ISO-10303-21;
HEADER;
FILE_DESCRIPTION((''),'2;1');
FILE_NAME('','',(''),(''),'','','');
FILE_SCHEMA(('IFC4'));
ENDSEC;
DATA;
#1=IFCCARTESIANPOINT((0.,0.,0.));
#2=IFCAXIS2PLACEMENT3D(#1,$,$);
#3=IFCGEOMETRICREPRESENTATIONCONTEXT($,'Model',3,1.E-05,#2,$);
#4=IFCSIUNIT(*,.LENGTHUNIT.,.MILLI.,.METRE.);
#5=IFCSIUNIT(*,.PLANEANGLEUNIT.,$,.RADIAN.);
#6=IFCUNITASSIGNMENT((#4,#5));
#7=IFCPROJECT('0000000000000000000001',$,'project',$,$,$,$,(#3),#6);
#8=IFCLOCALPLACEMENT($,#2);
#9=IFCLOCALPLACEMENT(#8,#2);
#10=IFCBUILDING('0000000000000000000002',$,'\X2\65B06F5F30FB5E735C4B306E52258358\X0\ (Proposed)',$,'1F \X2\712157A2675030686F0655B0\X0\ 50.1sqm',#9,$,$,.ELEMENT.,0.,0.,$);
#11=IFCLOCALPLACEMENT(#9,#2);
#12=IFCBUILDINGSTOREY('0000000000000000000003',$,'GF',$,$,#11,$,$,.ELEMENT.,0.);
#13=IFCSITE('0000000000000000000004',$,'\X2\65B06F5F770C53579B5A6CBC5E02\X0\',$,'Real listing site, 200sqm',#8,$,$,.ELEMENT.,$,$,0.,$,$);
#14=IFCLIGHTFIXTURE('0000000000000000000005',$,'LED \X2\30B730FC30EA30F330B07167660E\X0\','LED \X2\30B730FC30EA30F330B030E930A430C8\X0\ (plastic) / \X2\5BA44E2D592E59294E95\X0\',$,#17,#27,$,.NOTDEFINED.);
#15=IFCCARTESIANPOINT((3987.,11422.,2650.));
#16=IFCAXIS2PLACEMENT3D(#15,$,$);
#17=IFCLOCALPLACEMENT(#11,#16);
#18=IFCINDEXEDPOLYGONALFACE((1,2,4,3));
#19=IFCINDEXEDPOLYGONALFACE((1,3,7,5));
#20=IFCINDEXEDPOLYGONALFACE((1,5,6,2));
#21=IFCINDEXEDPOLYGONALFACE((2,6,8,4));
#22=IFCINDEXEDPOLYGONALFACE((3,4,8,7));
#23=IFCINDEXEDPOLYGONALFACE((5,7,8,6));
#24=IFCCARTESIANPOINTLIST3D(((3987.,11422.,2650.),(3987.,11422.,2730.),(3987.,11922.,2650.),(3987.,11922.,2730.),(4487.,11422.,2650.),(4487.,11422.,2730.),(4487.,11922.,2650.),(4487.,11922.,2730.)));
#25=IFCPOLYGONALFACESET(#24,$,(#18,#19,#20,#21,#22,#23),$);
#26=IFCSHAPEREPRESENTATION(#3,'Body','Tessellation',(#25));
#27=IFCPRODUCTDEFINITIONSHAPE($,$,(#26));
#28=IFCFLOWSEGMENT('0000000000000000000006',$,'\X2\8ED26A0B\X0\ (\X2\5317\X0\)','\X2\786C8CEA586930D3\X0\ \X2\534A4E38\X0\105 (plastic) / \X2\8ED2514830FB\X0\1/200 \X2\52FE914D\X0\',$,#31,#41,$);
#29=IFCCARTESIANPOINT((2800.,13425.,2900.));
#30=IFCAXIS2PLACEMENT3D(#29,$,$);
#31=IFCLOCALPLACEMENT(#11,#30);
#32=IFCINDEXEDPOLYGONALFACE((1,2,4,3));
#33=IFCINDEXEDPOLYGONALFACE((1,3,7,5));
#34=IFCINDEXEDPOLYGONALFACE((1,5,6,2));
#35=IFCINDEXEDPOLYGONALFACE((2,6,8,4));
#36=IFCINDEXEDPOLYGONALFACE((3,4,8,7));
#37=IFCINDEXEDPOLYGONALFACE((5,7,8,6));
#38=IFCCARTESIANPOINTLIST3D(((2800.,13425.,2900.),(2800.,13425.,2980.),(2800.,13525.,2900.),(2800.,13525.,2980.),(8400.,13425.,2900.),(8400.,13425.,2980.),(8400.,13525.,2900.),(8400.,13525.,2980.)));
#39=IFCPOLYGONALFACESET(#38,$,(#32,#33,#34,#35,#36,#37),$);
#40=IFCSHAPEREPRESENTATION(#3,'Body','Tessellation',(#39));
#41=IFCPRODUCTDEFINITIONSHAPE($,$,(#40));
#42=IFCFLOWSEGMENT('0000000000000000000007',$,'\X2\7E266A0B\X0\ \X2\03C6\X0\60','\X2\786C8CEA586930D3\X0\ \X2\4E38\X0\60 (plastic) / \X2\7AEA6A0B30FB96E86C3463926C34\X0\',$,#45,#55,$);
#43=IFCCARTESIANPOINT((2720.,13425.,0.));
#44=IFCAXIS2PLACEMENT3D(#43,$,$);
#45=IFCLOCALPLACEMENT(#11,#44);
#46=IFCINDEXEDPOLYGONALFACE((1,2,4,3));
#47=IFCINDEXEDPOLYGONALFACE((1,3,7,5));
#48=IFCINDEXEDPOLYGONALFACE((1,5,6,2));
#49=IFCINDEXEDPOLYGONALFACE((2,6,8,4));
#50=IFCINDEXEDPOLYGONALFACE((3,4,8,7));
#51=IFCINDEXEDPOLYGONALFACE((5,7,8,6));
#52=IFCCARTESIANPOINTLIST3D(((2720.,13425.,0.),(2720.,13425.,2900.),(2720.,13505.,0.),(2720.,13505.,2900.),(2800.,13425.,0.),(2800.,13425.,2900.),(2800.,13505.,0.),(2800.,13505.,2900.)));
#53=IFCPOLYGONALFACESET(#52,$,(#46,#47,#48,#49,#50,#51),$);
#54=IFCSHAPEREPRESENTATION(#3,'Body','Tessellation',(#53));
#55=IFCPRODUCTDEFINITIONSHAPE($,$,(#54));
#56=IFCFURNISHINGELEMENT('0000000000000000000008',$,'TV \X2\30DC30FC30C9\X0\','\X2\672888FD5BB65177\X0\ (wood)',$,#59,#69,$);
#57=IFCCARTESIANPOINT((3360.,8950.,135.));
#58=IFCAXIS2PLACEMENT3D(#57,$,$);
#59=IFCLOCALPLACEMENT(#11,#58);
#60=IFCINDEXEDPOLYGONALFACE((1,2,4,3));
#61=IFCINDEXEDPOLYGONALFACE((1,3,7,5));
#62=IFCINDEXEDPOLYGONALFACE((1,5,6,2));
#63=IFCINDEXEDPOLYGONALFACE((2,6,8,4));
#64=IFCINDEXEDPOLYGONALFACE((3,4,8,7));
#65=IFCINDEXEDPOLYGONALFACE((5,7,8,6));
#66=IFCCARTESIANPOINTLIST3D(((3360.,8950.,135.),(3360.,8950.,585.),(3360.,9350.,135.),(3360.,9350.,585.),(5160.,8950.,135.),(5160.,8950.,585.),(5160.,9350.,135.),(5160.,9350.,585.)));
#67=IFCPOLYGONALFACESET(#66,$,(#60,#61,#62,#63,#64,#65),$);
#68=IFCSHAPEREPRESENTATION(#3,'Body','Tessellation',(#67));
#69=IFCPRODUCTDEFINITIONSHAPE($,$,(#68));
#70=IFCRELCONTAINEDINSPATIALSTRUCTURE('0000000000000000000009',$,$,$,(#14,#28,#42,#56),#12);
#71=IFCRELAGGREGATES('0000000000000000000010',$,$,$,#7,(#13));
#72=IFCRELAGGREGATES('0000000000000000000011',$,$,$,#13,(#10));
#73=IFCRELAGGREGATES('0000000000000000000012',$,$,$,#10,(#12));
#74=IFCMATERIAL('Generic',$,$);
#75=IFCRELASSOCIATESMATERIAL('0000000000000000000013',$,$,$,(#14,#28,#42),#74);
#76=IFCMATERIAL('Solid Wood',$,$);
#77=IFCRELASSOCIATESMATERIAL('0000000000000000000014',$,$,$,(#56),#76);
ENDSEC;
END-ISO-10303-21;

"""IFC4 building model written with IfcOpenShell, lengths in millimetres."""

from ifc_helpers import new_model, si_unit, frame, frame_2d, origin, place, context, project, spatial, rectangle, extrude, material, element, save


model = new_model("IFC4")

# Units and contexts
model_context = context("Model", 3, precision=1e-05, world=origin())
ifc_project = project(units=[si_unit("LENGTHUNIT", "METRE", prefix="MILLI"), si_unit("PLANEANGLEUNIT", "RADIAN")], contexts=[model_context])

# Site, building, storey
site_placement = place(None, origin())
site = spatial("IfcSite", under=ifc_project, at=site_placement, Name="新潟県南魚沼市", ObjectType="Real listing site, 200sqm", CompositionType="ELEMENT", RefElevation=0.0)
building_placement = place(site_placement, origin())
building = spatial("IfcBuilding", under=site, at=building_placement, Name="新潟・平屋の別荘 (Proposed)", ObjectType="1F 無垢材と漆喰 50.1sqm", CompositionType="ELEMENT", ElevationOfRefHeight=0.0, ElevationOfTerrain=0.0)
storey_placement = place(building_placement, origin())
storey = spatial("IfcBuildingStorey", under=building, at=storey_placement, Name="GF", CompositionType="ELEMENT", Elevation=0.0)

# Shared definitions
ifc_material_1 = material(Name="Solid Wood")

# Shared definitions
ifc_material_2 = material(Name="Generic")

# Light fixture
light_fixture_placement = place(storey_placement, frame((3987.0, 11422.0, 2650.0)))
element("IfcLightFixture", 1, at=light_fixture_placement, inside=storey, material=ifc_material_2, Name="LED シーリング照明", Description="LED シーリングライト (plastic) / 室中央天井", PredefinedType="NOTDEFINED", context=model_context, shape_type="SweptSolid", body=[
    extrude(rectangle(XDim=500.0, YDim=500.0, at=frame_2d((250.0, 250.0))), frame((3987.0, 11422.0, 2650.0)), (0.0, 0.0, 1.0), 80.0),
])

# Flow segments
flow_segment_1_placement = place(storey_placement, frame((2800.0, 13425.0, 2900.0)))
element("IfcFlowSegment", 2, at=flow_segment_1_placement, inside=storey, material=ifc_material_2, Name="軒樋 (北)", Description="硬質塩ビ 半丸105 (plastic) / 軒先・1/200 勾配", context=model_context, shape_type="SweptSolid", body=[
    extrude(rectangle(XDim=5600.0, YDim=100.0, at=frame_2d((2800.0, 50.0))), frame((2800.0, 13425.0, 2900.0)), (0.0, 0.0, 1.0), 80.0),
])
flow_segment_2_placement = place(storey_placement, frame((2720.0, 13425.0, 0.0)))
element("IfcFlowSegment", 3, at=flow_segment_2_placement, inside=storey, material=ifc_material_2, Name="縦樋 φ60", Description="硬質塩ビ 丸60 (plastic) / 竪樋・雨水排水", context=model_context, shape_type="SweptSolid", body=[
    extrude(rectangle(XDim=80.0, YDim=80.0, at=frame_2d((40.0, 40.0))), frame((2720.0, 13425.0, 0.0)), (0.0, 0.0, 1.0), 2900.0),
])

# Furnishing element
furnishing_placement = place(storey_placement, frame((3360.0, 8950.0, 135.0)))
element("IfcFurnishingElement", 4, at=furnishing_placement, inside=storey, material=ifc_material_1, Name="TV ボード", Description="木製家具 (wood)", context=model_context, shape_type="SweptSolid", body=[
    extrude(rectangle(XDim=1800.0, YDim=400.0, at=frame_2d((900.0, 200.0))), frame((3360.0, 8950.0, 135.0)), (0.0, 0.0, 1.0), 450.0),
])

save(model, "model.ifc")
